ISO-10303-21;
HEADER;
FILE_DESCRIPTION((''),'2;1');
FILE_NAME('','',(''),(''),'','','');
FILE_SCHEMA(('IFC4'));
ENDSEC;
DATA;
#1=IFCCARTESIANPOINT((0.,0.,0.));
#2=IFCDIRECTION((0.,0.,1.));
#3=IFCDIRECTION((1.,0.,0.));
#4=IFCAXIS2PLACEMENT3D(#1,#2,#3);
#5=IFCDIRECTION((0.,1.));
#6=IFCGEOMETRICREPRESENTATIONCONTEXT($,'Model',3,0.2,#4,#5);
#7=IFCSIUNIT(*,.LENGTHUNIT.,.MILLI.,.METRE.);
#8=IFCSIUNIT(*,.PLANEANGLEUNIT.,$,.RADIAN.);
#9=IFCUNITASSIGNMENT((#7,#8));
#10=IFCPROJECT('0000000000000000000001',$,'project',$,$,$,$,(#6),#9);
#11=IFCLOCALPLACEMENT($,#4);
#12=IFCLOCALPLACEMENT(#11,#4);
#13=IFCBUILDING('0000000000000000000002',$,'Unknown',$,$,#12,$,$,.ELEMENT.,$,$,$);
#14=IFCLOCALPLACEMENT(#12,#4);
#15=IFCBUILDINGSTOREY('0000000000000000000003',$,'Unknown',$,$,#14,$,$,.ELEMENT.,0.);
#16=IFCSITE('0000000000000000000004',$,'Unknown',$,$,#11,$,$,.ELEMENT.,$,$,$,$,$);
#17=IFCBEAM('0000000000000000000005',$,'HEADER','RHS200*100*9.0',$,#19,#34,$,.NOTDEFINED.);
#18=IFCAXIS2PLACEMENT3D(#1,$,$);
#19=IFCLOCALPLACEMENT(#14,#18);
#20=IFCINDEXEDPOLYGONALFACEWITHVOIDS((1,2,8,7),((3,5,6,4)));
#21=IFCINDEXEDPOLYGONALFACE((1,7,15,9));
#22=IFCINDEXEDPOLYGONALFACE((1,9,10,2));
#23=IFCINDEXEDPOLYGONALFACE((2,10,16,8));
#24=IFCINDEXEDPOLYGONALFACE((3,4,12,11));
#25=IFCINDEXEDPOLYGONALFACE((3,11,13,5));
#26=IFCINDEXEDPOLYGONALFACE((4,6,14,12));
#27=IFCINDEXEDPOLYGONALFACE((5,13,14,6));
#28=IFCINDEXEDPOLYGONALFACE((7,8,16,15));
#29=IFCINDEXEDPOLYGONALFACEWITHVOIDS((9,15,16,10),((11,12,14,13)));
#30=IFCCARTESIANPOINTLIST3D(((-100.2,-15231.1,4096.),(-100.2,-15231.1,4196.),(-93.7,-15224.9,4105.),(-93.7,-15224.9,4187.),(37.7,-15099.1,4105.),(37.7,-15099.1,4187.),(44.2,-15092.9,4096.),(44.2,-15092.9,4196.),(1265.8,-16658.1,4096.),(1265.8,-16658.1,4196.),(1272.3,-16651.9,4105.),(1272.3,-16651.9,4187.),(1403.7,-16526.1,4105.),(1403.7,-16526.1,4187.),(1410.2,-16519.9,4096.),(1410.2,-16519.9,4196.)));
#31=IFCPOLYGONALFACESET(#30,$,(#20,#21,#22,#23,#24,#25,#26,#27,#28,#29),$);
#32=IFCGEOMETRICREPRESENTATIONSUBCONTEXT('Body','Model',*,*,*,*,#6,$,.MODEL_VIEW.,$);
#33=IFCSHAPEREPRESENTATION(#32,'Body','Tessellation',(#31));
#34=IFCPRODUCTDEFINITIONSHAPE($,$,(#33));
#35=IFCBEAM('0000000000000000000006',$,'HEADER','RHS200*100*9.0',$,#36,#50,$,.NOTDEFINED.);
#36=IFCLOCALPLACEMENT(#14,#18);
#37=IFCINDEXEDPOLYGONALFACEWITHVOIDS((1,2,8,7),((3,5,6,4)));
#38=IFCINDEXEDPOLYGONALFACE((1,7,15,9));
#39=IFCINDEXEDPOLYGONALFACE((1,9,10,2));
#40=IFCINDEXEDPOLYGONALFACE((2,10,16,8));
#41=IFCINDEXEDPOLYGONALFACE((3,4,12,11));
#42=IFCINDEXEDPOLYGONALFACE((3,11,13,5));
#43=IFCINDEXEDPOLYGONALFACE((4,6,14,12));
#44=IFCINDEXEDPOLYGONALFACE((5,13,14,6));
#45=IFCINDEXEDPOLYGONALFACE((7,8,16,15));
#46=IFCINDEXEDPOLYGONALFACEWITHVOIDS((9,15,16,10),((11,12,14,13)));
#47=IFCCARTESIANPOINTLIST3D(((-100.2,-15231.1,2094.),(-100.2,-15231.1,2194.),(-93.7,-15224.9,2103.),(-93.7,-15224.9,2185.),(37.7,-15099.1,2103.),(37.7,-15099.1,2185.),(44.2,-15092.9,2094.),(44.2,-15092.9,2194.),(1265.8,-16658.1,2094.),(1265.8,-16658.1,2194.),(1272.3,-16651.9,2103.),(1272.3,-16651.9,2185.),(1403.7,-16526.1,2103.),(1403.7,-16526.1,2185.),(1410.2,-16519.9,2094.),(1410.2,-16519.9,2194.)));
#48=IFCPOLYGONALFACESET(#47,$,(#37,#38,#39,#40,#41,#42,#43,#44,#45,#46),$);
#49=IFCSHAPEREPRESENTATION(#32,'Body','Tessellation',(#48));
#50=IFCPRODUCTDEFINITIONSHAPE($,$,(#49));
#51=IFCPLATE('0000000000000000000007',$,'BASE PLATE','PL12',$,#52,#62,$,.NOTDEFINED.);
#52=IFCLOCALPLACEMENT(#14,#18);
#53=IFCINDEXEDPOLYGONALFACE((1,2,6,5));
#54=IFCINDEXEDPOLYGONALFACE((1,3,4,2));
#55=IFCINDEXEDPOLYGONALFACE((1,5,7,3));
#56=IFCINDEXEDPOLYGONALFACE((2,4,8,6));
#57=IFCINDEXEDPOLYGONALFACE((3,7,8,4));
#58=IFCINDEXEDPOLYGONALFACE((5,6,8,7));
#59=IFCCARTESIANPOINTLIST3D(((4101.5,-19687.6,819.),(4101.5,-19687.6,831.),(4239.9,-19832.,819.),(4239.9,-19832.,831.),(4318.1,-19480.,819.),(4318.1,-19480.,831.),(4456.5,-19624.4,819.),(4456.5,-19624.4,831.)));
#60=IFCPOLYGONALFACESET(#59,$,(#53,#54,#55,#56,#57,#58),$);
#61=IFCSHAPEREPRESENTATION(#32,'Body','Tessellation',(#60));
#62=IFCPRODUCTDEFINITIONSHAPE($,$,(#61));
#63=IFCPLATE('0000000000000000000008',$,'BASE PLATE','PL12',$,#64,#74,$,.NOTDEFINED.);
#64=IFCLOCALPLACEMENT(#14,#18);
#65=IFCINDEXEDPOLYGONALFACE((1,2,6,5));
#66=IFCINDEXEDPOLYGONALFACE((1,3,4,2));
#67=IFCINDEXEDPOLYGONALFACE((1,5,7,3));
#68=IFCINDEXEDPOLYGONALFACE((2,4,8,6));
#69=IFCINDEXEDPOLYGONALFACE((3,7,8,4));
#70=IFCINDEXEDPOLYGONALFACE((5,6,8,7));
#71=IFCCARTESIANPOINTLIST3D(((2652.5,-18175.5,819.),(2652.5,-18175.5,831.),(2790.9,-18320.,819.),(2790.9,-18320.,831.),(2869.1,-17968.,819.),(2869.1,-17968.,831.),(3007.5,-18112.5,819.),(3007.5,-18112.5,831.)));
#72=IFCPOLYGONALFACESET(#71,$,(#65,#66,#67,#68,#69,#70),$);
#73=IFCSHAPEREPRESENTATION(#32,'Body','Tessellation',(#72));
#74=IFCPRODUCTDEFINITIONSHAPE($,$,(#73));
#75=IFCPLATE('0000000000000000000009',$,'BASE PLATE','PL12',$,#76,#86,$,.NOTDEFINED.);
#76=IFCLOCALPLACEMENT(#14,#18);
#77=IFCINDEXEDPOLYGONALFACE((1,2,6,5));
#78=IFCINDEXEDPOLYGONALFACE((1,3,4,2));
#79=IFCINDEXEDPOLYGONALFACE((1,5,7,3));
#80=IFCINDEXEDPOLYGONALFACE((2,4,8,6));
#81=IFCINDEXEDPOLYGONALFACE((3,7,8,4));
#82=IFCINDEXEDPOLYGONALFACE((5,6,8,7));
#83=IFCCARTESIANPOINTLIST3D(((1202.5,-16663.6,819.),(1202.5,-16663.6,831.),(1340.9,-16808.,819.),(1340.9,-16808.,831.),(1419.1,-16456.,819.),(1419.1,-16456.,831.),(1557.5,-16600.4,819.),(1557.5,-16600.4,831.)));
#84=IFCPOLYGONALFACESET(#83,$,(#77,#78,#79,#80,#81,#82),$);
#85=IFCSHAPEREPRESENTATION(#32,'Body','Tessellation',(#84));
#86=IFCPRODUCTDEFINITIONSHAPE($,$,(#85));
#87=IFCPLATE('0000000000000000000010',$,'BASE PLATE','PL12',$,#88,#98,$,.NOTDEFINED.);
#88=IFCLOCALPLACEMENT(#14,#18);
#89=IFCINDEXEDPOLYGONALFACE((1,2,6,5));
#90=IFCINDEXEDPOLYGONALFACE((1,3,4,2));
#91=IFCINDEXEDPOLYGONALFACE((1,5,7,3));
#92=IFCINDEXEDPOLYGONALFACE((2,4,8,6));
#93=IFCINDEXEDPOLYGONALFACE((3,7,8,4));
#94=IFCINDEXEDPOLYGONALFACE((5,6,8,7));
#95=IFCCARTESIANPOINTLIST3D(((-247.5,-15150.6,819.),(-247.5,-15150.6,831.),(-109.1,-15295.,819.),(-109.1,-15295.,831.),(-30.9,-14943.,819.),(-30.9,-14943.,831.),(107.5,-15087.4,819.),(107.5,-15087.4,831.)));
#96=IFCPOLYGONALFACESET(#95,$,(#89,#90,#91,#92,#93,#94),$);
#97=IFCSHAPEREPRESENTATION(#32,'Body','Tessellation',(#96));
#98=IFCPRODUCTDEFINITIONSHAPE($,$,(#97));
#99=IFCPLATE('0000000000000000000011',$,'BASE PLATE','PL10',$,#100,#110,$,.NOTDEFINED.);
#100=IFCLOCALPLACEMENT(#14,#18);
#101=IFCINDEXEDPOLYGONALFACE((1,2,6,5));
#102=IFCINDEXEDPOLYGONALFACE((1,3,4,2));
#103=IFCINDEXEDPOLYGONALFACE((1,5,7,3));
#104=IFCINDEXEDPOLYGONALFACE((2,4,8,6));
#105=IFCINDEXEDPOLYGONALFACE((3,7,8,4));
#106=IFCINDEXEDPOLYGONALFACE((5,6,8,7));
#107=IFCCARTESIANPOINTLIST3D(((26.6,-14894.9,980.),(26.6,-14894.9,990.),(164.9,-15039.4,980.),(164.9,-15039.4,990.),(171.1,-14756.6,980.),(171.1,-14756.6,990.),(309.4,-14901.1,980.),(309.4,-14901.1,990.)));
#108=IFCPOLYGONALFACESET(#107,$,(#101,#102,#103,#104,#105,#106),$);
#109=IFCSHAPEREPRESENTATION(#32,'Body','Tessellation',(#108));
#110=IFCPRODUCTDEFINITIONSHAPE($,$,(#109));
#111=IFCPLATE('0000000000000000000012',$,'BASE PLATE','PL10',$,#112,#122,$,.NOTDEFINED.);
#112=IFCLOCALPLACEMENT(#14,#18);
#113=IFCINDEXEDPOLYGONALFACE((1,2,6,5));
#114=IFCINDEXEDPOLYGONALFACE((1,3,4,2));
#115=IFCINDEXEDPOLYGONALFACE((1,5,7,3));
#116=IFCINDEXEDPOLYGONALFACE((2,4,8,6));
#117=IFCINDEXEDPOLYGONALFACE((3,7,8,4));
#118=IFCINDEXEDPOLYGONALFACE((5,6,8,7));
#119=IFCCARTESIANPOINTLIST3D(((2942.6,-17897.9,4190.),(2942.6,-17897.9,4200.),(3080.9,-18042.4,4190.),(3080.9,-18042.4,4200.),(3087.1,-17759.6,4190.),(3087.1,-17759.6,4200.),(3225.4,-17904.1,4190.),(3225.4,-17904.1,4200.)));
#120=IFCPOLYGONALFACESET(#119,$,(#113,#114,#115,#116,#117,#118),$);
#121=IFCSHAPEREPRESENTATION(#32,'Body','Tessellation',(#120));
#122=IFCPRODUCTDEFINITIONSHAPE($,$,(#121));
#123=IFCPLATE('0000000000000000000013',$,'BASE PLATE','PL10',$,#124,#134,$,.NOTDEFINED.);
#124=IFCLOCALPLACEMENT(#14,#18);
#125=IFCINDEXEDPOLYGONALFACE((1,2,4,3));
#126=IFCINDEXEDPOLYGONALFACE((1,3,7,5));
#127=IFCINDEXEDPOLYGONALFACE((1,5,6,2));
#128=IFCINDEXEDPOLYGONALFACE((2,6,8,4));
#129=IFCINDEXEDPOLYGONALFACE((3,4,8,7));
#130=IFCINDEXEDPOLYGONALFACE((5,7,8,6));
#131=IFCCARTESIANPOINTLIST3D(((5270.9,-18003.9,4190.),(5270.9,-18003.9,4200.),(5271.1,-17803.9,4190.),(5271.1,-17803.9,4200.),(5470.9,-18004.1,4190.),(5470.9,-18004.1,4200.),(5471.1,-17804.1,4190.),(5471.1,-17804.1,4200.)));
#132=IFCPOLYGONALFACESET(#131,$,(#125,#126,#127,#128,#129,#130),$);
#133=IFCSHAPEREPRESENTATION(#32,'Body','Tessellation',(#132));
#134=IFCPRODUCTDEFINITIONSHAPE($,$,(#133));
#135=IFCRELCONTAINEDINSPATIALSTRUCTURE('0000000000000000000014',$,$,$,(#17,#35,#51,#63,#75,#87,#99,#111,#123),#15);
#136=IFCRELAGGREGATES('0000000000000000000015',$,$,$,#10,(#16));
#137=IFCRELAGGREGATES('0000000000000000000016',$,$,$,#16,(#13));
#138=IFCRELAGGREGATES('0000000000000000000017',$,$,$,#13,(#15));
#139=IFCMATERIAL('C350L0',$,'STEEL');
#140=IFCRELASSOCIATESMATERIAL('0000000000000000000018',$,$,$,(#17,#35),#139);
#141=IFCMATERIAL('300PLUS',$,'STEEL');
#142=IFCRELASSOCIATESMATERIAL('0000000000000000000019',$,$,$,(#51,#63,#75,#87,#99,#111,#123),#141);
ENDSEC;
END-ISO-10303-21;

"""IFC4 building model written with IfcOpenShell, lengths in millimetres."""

from ifc_helpers import new_model, si_unit, direction, frame, origin_with_axes, place, context, subcontext, project, spatial, line, indexed_curve, outline, extrude, material, element, save


model = new_model("IFC4")

# Units and contexts
model_context = context("Model", 3, precision=0.2, world=origin_with_axes(), true_north=direction((0.0, 1.0)))
body_context = subcontext(model_context, "Body", "Model", "MODEL_VIEW")
ifc_project = project(units=[si_unit("LENGTHUNIT", "METRE", prefix="MILLI"), si_unit("PLANEANGLEUNIT", "RADIAN")], contexts=[model_context])

# Site, building, storey
site_placement = place(None, origin_with_axes())
site = spatial("IfcSite", under=ifc_project, at=site_placement, Name="Unknown", CompositionType="ELEMENT")
building_placement = place(site_placement, origin_with_axes())
building = spatial("IfcBuilding", under=site, at=building_placement, Name="Unknown", CompositionType="ELEMENT")
storey_placement = place(building_placement, origin_with_axes())
storey = spatial("IfcBuildingStorey", under=building, at=storey_placement, Name="Unknown", CompositionType="ELEMENT", Elevation=0.0)

# Shared definitions
ifc_material_1 = material(Name="C350L0", Category="STEEL")

# Beams
for number, where, z_axis, x_axis, name in (
    (1, (-28.0, -15162.0, 4146.0), (0.0, 0.0, 1.0), (0.691498, -0.722378, 0.0), "HEADER"),
    (2, (-28.0, -15162.0, 2144.0), (0.0, 0.0, 1.0), (0.691498, -0.722378, 0.0), "HEADER"),
):
    element("IfcBeam", number, at=place(storey_placement, frame(where, z_axis=z_axis, x_axis=x_axis)), inside=storey, material=ifc_material_1, Name=name, Description="RHS200*100*9.0", PredefinedType="NOTDEFINED", context=body_context, shape_type="SolidModel", body=[
        extrude(outline(indexed_curve([(-50.0, -100.0), (50.0, -100.0), (50.0, 100.0), (-50.0, 100.0)], segments=[line(1, 2, 3, 4, 1)]), holes=[indexed_curve([(-41.0, -91.0), (-41.0, 91.0), (41.0, 91.0), (41.0, -91.0)], segments=[line(1, 2, 3, 4, 1)])]), frame((0.0, 0.0, 0.0), z_axis=(-1.0, 0.0, 0.0), x_axis=(0.0, 0.0, 1.0)), (0.0, 0.0, -1.0), 1975.4),
    ])

# Plates
ifc_material_2 = material(Name="300PLUS", Category="STEEL")
plate_1_placement = place(storey_placement, frame((4239.9, -19832.0, 825.0), z_axis=(0.0, 0.0, 1.0), x_axis=(0.721947, 0.691949, 0.0)))
element("IfcPlate", 3, at=plate_1_placement, inside=storey, material=ifc_material_2, Name="BASE PLATE", Description="PL12", PredefinedType="NOTDEFINED", context=body_context, shape_type="SolidModel", body=[
    extrude(outline(indexed_curve([(0.0, 0.0), (300.0, 0.0), (300.0, 200.0), (0.0, 200.0)], segments=[line(1, 2, 3, 4, 1)])), frame((0.0, 0.0, 6.0), z_axis=(0.0, 0.0, 1.0), x_axis=(1.0, 0.0, 0.0)), (0.0, 0.0, -1.0), 12.0),
])
plate_2_placement = place(storey_placement, frame((2790.9, -18320.0, 825.0), z_axis=(0.0, 0.0, 1.0), x_axis=(0.722113, 0.691775, 0.0)))
element("IfcPlate", 4, at=plate_2_placement, inside=storey, material=ifc_material_2, Name="BASE PLATE", Description="PL12", PredefinedType="NOTDEFINED", context=body_context, shape_type="SolidModel", body=[
    extrude(outline(indexed_curve([(0.0, 0.0), (300.0, 0.0), (300.0, 200.1), (0.0, 200.1)], segments=[line(1, 2, 3, 4, 1)])), frame((0.0, 0.0, 6.0), z_axis=(0.0, 0.0, 1.0), x_axis=(1.0, 0.0, 0.0)), (0.0, 0.0, -1.0), 12.0),
])
for number, where, z_axis, x_axis, name in (
    (5, (1340.9, -16808.0, 825.0), (0.0, 0.0, 1.0), (0.721947, 0.691949, 0.0), "BASE PLATE"),
    (6, (-109.1, -15295.0, 825.0), (0.0, 0.0, 1.0), (0.721947, 0.691949, 0.0), "BASE PLATE"),
):
    element("IfcPlate", number, at=place(storey_placement, frame(where, z_axis=z_axis, x_axis=x_axis)), inside=storey, material=ifc_material_2, Name=name, Description="PL12", PredefinedType="NOTDEFINED", context=body_context, shape_type="SolidModel", body=[
        extrude(outline(indexed_curve([(0.0, 0.0), (300.0, 0.0), (300.0, 200.0), (0.0, 200.0)], segments=[line(1, 2, 3, 4, 1)])), frame((0.0, 0.0, 6.0), z_axis=(0.0, 0.0, 1.0), x_axis=(1.0, 0.0, 0.0)), (0.0, 0.0, -1.0), 12.0),
    ])
for number, where, z_axis, x_axis, name in (
    (7, (26.6, -14894.9, 985.0), (0.0, 0.0, 1.0), (0.691438, -0.722436, 0.0), "BASE PLATE"),
    (8, (2942.6, -17897.9, 4195.0), (0.0, 0.0, 1.0), (0.691438, -0.722436, 0.0), "BASE PLATE"),
):
    element("IfcPlate", number, at=place(storey_placement, frame(where, z_axis=z_axis, x_axis=x_axis)), inside=storey, material=ifc_material_2, Name=name, Description="PL10", PredefinedType="NOTDEFINED", context=body_context, shape_type="SolidModel", body=[
        extrude(outline(indexed_curve([(0.0, 0.0), (200.0, 0.0), (200.0, 200.0), (0.0, 200.0)], segments=[line(1, 2, 3, 4, 1)])), frame((0.0, 0.0, 5.0), z_axis=(0.0, 0.0, 1.0), x_axis=(1.0, 0.0, 0.0)), (0.0, 0.0, -1.0), 10.0),
    ])
plate_3_placement = place(storey_placement, frame((5270.9, -18003.9, 4195.0), z_axis=(0.0, 0.0, 1.0), x_axis=(1.0, -0.001, 0.0)))
element("IfcPlate", 9, at=plate_3_placement, inside=storey, material=ifc_material_2, Name="BASE PLATE", Description="PL10", PredefinedType="NOTDEFINED", context=body_context, shape_type="SolidModel", body=[
    extrude(outline(indexed_curve([(0.0, 0.0), (200.0, 0.0), (200.0, 200.0), (0.0, 200.0)], segments=[line(1, 2, 3, 4, 1)])), frame((0.0, 0.0, 5.0), z_axis=(0.0, 0.0, 1.0), x_axis=(1.0, 0.0, 0.0)), (0.0, 0.0, -1.0), 10.0),
])

save(model, "model.ifc")
